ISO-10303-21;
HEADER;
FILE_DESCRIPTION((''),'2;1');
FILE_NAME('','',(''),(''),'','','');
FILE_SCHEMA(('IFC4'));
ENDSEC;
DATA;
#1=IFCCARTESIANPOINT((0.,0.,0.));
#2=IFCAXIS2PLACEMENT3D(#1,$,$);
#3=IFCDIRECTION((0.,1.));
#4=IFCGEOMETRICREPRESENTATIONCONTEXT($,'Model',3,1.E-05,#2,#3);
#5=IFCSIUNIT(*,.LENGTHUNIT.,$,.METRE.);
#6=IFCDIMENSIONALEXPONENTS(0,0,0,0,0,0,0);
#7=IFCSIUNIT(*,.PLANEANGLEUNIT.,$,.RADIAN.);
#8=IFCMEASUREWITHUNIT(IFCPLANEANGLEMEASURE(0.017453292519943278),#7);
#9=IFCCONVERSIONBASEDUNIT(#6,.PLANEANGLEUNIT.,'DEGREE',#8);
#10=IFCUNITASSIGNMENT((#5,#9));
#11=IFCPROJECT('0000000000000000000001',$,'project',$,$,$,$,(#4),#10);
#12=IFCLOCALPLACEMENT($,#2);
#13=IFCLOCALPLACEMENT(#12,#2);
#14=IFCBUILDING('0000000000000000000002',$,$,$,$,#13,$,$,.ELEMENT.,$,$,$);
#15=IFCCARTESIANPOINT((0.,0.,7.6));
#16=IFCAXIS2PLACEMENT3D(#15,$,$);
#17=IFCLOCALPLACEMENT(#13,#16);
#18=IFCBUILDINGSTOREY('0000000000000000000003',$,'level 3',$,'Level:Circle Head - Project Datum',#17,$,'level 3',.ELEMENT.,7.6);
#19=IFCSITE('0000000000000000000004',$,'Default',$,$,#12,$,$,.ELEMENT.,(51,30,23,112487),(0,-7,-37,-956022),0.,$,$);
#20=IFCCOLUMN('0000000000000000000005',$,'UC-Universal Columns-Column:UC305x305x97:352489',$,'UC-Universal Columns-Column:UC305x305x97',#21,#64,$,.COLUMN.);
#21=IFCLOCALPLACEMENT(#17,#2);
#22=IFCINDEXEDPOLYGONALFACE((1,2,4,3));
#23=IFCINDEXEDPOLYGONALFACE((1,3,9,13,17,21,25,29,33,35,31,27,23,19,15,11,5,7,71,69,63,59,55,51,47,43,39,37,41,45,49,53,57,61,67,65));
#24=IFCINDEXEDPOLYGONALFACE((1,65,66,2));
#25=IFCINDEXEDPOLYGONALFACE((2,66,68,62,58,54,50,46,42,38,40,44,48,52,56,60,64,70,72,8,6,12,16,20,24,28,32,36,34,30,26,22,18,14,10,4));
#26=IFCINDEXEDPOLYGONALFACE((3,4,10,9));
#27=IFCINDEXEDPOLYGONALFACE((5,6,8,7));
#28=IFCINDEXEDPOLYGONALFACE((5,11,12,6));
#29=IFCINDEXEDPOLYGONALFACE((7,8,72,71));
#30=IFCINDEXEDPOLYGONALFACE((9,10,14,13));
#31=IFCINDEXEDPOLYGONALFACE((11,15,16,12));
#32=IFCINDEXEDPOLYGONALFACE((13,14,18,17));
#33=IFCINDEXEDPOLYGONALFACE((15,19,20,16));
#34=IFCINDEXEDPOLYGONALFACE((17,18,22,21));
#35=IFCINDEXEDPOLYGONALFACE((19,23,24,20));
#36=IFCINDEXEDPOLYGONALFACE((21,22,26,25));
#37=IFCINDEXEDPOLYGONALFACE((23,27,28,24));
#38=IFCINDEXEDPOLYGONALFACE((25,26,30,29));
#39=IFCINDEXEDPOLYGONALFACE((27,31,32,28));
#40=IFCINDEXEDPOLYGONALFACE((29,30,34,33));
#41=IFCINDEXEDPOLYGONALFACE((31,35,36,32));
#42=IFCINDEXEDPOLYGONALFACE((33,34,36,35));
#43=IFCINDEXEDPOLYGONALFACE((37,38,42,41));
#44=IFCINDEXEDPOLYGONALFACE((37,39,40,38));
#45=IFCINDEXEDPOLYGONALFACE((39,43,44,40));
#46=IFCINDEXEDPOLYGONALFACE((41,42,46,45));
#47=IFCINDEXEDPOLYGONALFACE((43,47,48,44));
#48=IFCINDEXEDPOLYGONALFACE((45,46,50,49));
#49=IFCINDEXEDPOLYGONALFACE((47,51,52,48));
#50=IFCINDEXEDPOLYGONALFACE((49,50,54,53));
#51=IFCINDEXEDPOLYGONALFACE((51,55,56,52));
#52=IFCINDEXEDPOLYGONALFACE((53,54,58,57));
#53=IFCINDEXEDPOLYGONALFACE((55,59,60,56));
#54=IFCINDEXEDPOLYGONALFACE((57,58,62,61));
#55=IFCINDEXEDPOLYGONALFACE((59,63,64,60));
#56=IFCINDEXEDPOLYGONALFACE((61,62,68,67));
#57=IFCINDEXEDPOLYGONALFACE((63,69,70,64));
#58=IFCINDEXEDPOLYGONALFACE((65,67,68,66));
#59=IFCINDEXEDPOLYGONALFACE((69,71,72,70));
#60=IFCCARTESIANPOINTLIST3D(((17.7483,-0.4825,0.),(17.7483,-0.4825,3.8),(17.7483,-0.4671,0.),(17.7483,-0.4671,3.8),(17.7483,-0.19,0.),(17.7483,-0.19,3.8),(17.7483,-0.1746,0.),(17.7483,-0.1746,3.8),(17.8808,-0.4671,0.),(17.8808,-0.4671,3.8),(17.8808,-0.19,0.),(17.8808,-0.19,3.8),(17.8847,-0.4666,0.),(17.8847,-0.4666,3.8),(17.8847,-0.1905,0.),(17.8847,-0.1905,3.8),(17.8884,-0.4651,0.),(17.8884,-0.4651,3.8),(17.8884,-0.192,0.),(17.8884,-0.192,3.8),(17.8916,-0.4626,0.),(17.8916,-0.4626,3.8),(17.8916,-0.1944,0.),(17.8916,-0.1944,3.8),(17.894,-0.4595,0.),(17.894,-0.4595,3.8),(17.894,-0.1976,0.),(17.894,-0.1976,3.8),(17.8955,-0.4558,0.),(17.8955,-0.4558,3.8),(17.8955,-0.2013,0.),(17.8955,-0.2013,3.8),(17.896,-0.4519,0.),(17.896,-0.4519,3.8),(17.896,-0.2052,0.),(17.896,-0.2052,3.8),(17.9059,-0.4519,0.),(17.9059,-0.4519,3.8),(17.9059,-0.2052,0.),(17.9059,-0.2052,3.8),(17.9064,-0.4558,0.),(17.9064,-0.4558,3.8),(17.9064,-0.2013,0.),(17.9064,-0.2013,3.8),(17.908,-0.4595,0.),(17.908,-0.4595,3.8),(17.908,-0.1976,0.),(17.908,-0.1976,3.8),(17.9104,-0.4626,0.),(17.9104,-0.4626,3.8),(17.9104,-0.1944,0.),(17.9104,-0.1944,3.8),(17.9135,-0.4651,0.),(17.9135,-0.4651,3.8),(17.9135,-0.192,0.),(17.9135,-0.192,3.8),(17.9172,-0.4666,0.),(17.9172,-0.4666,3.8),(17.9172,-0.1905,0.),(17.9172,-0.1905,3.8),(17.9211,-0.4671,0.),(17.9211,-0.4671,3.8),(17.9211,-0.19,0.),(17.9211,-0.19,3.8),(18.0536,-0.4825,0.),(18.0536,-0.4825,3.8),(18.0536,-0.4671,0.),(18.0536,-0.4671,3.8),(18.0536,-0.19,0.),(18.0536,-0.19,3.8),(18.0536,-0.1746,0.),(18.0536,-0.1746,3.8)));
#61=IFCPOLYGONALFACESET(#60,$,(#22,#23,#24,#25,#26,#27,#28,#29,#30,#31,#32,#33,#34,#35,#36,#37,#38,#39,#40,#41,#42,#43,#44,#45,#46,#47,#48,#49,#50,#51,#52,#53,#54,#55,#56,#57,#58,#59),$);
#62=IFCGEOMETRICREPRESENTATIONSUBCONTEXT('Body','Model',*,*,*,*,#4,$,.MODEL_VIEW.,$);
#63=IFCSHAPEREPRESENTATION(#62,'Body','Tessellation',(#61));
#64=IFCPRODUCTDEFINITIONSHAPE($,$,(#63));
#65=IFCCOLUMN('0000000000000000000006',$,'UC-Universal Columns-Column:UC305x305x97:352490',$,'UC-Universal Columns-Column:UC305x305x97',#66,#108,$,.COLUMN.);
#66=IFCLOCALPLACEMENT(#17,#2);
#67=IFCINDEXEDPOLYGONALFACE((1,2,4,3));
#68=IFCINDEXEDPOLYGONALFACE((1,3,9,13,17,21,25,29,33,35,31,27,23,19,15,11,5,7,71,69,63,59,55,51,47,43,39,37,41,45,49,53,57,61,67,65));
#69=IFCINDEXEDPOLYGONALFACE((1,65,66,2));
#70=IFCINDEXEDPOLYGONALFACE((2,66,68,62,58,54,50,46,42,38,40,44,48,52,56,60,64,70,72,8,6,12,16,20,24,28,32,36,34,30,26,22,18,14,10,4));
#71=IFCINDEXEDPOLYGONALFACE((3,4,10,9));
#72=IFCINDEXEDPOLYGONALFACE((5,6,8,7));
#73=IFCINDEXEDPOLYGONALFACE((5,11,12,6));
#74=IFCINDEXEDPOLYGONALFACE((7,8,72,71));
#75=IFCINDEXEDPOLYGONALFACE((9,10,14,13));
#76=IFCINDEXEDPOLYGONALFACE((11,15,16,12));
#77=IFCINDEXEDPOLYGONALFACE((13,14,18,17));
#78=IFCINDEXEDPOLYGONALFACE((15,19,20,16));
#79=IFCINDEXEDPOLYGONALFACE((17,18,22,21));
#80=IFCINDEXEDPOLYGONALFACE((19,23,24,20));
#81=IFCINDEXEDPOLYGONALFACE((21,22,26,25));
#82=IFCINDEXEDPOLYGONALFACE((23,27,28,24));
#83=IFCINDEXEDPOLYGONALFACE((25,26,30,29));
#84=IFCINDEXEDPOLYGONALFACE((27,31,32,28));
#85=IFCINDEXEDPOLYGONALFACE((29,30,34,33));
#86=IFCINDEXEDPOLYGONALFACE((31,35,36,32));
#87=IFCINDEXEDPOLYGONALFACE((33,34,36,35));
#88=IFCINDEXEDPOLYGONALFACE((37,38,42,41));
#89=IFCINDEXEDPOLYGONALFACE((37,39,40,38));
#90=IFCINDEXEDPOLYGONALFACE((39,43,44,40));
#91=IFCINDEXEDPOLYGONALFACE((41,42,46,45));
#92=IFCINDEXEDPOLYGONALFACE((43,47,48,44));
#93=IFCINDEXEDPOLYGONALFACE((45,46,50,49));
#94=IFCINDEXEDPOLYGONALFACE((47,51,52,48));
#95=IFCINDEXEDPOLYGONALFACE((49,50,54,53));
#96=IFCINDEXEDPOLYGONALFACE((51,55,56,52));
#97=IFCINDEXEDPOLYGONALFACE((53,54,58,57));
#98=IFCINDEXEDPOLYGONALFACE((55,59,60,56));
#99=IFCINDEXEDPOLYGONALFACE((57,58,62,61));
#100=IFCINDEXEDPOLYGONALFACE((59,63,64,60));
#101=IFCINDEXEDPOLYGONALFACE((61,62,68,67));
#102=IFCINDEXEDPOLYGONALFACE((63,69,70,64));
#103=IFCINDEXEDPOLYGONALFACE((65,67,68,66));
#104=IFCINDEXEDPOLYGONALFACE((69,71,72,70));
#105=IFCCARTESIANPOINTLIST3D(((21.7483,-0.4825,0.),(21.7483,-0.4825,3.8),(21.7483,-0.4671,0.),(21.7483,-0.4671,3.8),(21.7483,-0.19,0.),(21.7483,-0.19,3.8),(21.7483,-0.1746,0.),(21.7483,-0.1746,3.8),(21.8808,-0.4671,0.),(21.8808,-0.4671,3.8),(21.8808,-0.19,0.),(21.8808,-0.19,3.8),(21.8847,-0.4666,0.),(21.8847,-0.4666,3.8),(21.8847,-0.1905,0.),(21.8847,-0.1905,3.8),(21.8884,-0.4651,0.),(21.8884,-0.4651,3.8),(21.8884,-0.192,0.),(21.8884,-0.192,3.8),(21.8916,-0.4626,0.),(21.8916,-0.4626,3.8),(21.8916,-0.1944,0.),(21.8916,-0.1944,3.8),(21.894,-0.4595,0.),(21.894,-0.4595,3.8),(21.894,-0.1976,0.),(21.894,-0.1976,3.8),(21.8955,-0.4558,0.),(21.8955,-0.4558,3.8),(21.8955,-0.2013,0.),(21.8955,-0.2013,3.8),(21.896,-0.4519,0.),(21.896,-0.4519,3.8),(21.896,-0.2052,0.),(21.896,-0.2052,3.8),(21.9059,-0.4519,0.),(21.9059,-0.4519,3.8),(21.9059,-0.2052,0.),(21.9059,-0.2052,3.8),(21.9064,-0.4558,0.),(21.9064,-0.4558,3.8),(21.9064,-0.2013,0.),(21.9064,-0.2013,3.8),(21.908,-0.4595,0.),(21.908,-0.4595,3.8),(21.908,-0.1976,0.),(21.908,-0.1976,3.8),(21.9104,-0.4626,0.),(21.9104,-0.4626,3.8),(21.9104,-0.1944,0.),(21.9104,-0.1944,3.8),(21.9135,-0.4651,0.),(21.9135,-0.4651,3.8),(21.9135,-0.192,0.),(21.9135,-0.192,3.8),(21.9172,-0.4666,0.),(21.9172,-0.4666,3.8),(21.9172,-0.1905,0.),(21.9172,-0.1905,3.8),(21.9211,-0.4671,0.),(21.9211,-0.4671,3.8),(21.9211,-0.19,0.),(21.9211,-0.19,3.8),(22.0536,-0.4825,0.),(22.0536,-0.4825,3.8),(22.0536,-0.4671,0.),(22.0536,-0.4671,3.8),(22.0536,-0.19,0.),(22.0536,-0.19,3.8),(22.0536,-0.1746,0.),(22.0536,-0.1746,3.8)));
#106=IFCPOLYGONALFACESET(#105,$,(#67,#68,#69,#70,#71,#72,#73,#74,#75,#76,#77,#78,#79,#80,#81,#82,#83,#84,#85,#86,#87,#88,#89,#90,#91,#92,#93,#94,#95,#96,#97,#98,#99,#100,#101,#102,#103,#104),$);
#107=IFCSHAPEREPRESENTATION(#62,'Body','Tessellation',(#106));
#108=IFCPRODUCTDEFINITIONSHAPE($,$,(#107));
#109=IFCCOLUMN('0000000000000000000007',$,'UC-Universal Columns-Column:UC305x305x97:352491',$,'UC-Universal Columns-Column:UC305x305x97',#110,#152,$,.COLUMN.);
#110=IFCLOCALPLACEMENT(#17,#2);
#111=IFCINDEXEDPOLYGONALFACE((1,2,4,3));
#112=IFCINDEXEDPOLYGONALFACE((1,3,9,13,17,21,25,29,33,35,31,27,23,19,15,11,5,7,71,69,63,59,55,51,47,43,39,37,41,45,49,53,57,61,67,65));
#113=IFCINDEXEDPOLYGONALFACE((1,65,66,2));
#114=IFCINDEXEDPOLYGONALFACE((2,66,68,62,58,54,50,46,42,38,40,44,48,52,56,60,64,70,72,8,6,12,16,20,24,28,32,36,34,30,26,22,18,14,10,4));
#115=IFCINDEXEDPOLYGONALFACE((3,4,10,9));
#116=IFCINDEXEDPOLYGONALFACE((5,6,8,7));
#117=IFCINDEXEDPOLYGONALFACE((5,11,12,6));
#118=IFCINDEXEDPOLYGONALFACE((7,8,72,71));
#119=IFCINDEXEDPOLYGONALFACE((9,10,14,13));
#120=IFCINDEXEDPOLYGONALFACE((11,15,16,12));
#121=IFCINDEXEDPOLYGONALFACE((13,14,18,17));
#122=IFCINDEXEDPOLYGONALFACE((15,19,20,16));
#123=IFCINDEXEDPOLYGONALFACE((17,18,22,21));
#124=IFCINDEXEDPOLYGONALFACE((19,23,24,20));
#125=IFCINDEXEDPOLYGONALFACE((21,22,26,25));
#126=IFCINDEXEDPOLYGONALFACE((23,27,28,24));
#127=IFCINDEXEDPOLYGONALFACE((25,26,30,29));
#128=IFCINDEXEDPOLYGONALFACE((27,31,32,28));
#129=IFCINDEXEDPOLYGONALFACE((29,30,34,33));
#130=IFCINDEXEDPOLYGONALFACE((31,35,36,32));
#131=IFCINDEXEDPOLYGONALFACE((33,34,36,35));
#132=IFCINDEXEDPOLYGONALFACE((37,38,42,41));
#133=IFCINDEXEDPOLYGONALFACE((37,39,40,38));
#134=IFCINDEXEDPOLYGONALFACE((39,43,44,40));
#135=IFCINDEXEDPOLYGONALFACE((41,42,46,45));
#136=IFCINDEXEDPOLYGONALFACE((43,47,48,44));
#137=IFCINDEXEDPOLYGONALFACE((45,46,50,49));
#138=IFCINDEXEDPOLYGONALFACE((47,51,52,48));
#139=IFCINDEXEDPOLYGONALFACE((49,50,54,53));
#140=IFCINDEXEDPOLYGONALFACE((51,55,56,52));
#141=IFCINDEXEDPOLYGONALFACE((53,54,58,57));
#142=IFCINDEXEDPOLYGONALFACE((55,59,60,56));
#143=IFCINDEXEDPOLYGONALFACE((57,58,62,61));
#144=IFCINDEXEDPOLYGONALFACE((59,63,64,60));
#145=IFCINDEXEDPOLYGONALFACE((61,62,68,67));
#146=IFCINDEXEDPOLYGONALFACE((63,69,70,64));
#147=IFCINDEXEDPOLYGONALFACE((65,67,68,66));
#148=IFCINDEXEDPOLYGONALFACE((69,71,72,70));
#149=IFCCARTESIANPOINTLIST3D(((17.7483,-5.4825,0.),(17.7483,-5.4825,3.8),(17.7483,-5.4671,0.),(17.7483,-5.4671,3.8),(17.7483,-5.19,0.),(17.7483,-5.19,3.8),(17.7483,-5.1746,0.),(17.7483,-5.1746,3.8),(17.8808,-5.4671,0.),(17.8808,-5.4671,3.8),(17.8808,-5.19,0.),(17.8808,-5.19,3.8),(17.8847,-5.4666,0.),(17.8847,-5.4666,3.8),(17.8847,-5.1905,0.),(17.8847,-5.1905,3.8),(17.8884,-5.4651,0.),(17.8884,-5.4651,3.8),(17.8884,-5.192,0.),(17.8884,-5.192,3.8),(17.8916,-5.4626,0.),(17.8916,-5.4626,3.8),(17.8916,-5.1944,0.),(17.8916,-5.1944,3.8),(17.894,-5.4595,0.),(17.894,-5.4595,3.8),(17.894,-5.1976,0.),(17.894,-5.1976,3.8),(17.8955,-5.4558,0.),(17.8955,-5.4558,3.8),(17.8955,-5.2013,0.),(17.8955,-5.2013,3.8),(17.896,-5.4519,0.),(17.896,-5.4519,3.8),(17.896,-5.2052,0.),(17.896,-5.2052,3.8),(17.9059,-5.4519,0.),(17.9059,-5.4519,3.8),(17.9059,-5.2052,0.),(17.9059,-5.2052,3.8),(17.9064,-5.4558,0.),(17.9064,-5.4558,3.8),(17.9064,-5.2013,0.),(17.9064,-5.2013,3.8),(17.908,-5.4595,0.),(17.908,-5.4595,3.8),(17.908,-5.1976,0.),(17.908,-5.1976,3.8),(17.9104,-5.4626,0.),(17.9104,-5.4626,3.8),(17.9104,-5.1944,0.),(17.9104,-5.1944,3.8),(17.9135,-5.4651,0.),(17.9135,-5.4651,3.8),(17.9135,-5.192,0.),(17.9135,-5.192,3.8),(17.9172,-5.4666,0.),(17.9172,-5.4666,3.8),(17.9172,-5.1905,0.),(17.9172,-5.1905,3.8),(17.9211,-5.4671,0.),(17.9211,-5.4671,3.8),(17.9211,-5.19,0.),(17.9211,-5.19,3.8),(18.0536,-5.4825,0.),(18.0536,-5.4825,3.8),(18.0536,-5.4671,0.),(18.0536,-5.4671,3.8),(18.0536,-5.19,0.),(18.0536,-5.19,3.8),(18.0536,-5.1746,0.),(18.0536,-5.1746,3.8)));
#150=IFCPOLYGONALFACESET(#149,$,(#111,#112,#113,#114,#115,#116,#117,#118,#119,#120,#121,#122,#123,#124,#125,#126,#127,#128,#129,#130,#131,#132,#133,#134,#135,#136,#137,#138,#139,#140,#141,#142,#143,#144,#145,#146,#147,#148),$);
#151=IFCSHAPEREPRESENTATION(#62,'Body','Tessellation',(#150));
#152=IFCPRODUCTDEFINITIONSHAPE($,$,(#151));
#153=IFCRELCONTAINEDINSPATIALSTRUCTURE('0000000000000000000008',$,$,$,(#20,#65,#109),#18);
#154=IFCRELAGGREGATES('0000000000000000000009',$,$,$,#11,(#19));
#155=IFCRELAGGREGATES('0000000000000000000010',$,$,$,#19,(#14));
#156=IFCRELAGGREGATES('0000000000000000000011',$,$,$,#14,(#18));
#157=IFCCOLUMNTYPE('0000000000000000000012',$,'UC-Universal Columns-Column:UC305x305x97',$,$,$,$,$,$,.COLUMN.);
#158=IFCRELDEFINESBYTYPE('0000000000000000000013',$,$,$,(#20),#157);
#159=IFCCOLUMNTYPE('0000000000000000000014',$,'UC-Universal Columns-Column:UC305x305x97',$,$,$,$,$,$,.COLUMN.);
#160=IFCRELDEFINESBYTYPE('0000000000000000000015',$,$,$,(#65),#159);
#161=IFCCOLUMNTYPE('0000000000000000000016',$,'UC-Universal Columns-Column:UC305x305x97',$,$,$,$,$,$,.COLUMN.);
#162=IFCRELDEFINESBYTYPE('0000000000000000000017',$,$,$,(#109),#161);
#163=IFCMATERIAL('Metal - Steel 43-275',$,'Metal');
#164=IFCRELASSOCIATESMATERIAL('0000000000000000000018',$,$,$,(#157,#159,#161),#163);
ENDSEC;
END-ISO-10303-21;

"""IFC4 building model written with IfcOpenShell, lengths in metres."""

from ifc_helpers import new_model, entity, si_unit, converted_unit, direction, frame, frame_2d, origin, place, context, subcontext, project, spatial, i_section, extrude, source, transform, mapped, material, material_profile, profile_set, type_object, type_shapes, element, save


model = new_model("IFC4")

# Units and contexts
model_context = context("Model", 3, precision=1e-05, world=origin(), true_north=direction((0.0, 1.0)))
body_context = subcontext(model_context, "Body", "Model", "MODEL_VIEW")
ifc_project = project(units=[si_unit("LENGTHUNIT", "METRE"), converted_unit("PLANEANGLEUNIT", "DEGREE", entity("IfcPlaneAngleMeasure", 0.017453292519943278), si_unit("PLANEANGLEUNIT", "RADIAN"), dimensions=[0, 0, 0, 0, 0, 0, 0])], contexts=[model_context])

# Site, building, storey
site_placement = place(None, origin())
site = spatial("IfcSite", under=ifc_project, at=site_placement, Name="Default", CompositionType="ELEMENT", RefLatitude=(51, 30, 23, 112487), RefLongitude=(0, -7, -37, -956022), RefElevation=0.0)
building_placement = place(site_placement, origin())
building = spatial("IfcBuilding", under=site, at=building_placement, CompositionType="ELEMENT")
storey_placement = place(building_placement, frame((0.0, 0.0, 7.6)))
storey = spatial("IfcBuildingStorey", under=building, at=storey_placement, Name="level 3", ObjectType="Level:Circle Head - Project Datum", LongName="level 3", CompositionType="ELEMENT", Elevation=7.6)

# Columns
ifc_material_1 = material(Name="Metal - Steel 43-275", Category="Metal")
ifc_material_profile_1 = material_profile(ifc_material_1, i_section(OverallWidth=0.3053, OverallDepth=0.3079, WebThickness=0.0099, FlangeThickness=0.0154, FilletRadius=0.0152, at=frame_2d((0.0, 0.0), x_axis=(1.0, 0.0))), Name="UC305x305x97")
ifc_profile_set_1 = profile_set([ifc_material_profile_1], Name="UC305x305x97")
column_type_1 = type_object("IfcColumnType", Name="UC-Universal Columns-Column:UC305x305x97", PredefinedType="COLUMN", material=ifc_profile_set_1)
shared_shape_1 = source(origin(), body_context, "Body", "SweptSolid", [
    extrude(i_section(OverallWidth=0.3053, OverallDepth=0.3079, WebThickness=0.0099, FlangeThickness=0.0154, FilletRadius=0.0152, at=frame_2d((0.0, 0.0), x_axis=(1.0, 0.0))), frame((17.901, -0.3285, 7.6), z_axis=(0.0, 0.0, 1.0), x_axis=(-1.0, 0.0, 0.0)), (0.0, 0.0, 1.0), 3.8),
])
type_shapes(column_type_1, [shared_shape_1])
column_1_placement = place(storey_placement, frame((0.0, 0.0, -7.6)))
element("IfcColumn", 1, at=column_1_placement, inside=storey, type_object=column_type_1, Name="UC-Universal Columns-Column:UC305x305x97:352489", ObjectType="UC-Universal Columns-Column:UC305x305x97", PredefinedType="COLUMN", context=body_context, shape_type="MappedRepresentation", body=[
    mapped(shared_shape_1, transform((0.0, 0.0, 0.0), scale=1.0)),
])
column_type_2 = type_object("IfcColumnType", Name="UC-Universal Columns-Column:UC305x305x97", PredefinedType="COLUMN", material=ifc_profile_set_1)
shared_shape_2 = source(origin(), body_context, "Body", "SweptSolid", [
    extrude(i_section(OverallWidth=0.3053, OverallDepth=0.3079, WebThickness=0.0099, FlangeThickness=0.0154, FilletRadius=0.0152, at=frame_2d((0.0, 0.0), x_axis=(1.0, 0.0))), frame((21.901, -0.3285, 7.6), z_axis=(0.0, 0.0, 1.0), x_axis=(-1.0, 0.0, 0.0)), (0.0, 0.0, 1.0), 3.8),
])
type_shapes(column_type_2, [shared_shape_2])
column_2_placement = place(storey_placement, frame((0.0, 0.0, -7.6)))
element("IfcColumn", 2, at=column_2_placement, inside=storey, type_object=column_type_2, Name="UC-Universal Columns-Column:UC305x305x97:352490", ObjectType="UC-Universal Columns-Column:UC305x305x97", PredefinedType="COLUMN", context=body_context, shape_type="MappedRepresentation", body=[
    mapped(shared_shape_2, transform((0.0, 0.0, 0.0), scale=1.0)),
])
column_type_3 = type_object("IfcColumnType", Name="UC-Universal Columns-Column:UC305x305x97", PredefinedType="COLUMN", material=ifc_profile_set_1)
shared_shape_3 = source(origin(), body_context, "Body", "SweptSolid", [
    extrude(i_section(OverallWidth=0.3053, OverallDepth=0.3079, WebThickness=0.0099, FlangeThickness=0.0154, FilletRadius=0.0152, at=frame_2d((0.0, 0.0), x_axis=(1.0, 0.0))), frame((17.901, -5.3285, 7.6), z_axis=(0.0, 0.0, 1.0), x_axis=(-1.0, 0.0, 0.0)), (0.0, 0.0, 1.0), 3.8),
])
type_shapes(column_type_3, [shared_shape_3])
column_3_placement = place(storey_placement, frame((0.0, 0.0, -7.6)))
element("IfcColumn", 3, at=column_3_placement, inside=storey, type_object=column_type_3, Name="UC-Universal Columns-Column:UC305x305x97:352491", ObjectType="UC-Universal Columns-Column:UC305x305x97", PredefinedType="COLUMN", context=body_context, shape_type="MappedRepresentation", body=[
    mapped(shared_shape_3, transform((0.0, 0.0, 0.0), scale=1.0)),
])

save(model, "model.ifc")
